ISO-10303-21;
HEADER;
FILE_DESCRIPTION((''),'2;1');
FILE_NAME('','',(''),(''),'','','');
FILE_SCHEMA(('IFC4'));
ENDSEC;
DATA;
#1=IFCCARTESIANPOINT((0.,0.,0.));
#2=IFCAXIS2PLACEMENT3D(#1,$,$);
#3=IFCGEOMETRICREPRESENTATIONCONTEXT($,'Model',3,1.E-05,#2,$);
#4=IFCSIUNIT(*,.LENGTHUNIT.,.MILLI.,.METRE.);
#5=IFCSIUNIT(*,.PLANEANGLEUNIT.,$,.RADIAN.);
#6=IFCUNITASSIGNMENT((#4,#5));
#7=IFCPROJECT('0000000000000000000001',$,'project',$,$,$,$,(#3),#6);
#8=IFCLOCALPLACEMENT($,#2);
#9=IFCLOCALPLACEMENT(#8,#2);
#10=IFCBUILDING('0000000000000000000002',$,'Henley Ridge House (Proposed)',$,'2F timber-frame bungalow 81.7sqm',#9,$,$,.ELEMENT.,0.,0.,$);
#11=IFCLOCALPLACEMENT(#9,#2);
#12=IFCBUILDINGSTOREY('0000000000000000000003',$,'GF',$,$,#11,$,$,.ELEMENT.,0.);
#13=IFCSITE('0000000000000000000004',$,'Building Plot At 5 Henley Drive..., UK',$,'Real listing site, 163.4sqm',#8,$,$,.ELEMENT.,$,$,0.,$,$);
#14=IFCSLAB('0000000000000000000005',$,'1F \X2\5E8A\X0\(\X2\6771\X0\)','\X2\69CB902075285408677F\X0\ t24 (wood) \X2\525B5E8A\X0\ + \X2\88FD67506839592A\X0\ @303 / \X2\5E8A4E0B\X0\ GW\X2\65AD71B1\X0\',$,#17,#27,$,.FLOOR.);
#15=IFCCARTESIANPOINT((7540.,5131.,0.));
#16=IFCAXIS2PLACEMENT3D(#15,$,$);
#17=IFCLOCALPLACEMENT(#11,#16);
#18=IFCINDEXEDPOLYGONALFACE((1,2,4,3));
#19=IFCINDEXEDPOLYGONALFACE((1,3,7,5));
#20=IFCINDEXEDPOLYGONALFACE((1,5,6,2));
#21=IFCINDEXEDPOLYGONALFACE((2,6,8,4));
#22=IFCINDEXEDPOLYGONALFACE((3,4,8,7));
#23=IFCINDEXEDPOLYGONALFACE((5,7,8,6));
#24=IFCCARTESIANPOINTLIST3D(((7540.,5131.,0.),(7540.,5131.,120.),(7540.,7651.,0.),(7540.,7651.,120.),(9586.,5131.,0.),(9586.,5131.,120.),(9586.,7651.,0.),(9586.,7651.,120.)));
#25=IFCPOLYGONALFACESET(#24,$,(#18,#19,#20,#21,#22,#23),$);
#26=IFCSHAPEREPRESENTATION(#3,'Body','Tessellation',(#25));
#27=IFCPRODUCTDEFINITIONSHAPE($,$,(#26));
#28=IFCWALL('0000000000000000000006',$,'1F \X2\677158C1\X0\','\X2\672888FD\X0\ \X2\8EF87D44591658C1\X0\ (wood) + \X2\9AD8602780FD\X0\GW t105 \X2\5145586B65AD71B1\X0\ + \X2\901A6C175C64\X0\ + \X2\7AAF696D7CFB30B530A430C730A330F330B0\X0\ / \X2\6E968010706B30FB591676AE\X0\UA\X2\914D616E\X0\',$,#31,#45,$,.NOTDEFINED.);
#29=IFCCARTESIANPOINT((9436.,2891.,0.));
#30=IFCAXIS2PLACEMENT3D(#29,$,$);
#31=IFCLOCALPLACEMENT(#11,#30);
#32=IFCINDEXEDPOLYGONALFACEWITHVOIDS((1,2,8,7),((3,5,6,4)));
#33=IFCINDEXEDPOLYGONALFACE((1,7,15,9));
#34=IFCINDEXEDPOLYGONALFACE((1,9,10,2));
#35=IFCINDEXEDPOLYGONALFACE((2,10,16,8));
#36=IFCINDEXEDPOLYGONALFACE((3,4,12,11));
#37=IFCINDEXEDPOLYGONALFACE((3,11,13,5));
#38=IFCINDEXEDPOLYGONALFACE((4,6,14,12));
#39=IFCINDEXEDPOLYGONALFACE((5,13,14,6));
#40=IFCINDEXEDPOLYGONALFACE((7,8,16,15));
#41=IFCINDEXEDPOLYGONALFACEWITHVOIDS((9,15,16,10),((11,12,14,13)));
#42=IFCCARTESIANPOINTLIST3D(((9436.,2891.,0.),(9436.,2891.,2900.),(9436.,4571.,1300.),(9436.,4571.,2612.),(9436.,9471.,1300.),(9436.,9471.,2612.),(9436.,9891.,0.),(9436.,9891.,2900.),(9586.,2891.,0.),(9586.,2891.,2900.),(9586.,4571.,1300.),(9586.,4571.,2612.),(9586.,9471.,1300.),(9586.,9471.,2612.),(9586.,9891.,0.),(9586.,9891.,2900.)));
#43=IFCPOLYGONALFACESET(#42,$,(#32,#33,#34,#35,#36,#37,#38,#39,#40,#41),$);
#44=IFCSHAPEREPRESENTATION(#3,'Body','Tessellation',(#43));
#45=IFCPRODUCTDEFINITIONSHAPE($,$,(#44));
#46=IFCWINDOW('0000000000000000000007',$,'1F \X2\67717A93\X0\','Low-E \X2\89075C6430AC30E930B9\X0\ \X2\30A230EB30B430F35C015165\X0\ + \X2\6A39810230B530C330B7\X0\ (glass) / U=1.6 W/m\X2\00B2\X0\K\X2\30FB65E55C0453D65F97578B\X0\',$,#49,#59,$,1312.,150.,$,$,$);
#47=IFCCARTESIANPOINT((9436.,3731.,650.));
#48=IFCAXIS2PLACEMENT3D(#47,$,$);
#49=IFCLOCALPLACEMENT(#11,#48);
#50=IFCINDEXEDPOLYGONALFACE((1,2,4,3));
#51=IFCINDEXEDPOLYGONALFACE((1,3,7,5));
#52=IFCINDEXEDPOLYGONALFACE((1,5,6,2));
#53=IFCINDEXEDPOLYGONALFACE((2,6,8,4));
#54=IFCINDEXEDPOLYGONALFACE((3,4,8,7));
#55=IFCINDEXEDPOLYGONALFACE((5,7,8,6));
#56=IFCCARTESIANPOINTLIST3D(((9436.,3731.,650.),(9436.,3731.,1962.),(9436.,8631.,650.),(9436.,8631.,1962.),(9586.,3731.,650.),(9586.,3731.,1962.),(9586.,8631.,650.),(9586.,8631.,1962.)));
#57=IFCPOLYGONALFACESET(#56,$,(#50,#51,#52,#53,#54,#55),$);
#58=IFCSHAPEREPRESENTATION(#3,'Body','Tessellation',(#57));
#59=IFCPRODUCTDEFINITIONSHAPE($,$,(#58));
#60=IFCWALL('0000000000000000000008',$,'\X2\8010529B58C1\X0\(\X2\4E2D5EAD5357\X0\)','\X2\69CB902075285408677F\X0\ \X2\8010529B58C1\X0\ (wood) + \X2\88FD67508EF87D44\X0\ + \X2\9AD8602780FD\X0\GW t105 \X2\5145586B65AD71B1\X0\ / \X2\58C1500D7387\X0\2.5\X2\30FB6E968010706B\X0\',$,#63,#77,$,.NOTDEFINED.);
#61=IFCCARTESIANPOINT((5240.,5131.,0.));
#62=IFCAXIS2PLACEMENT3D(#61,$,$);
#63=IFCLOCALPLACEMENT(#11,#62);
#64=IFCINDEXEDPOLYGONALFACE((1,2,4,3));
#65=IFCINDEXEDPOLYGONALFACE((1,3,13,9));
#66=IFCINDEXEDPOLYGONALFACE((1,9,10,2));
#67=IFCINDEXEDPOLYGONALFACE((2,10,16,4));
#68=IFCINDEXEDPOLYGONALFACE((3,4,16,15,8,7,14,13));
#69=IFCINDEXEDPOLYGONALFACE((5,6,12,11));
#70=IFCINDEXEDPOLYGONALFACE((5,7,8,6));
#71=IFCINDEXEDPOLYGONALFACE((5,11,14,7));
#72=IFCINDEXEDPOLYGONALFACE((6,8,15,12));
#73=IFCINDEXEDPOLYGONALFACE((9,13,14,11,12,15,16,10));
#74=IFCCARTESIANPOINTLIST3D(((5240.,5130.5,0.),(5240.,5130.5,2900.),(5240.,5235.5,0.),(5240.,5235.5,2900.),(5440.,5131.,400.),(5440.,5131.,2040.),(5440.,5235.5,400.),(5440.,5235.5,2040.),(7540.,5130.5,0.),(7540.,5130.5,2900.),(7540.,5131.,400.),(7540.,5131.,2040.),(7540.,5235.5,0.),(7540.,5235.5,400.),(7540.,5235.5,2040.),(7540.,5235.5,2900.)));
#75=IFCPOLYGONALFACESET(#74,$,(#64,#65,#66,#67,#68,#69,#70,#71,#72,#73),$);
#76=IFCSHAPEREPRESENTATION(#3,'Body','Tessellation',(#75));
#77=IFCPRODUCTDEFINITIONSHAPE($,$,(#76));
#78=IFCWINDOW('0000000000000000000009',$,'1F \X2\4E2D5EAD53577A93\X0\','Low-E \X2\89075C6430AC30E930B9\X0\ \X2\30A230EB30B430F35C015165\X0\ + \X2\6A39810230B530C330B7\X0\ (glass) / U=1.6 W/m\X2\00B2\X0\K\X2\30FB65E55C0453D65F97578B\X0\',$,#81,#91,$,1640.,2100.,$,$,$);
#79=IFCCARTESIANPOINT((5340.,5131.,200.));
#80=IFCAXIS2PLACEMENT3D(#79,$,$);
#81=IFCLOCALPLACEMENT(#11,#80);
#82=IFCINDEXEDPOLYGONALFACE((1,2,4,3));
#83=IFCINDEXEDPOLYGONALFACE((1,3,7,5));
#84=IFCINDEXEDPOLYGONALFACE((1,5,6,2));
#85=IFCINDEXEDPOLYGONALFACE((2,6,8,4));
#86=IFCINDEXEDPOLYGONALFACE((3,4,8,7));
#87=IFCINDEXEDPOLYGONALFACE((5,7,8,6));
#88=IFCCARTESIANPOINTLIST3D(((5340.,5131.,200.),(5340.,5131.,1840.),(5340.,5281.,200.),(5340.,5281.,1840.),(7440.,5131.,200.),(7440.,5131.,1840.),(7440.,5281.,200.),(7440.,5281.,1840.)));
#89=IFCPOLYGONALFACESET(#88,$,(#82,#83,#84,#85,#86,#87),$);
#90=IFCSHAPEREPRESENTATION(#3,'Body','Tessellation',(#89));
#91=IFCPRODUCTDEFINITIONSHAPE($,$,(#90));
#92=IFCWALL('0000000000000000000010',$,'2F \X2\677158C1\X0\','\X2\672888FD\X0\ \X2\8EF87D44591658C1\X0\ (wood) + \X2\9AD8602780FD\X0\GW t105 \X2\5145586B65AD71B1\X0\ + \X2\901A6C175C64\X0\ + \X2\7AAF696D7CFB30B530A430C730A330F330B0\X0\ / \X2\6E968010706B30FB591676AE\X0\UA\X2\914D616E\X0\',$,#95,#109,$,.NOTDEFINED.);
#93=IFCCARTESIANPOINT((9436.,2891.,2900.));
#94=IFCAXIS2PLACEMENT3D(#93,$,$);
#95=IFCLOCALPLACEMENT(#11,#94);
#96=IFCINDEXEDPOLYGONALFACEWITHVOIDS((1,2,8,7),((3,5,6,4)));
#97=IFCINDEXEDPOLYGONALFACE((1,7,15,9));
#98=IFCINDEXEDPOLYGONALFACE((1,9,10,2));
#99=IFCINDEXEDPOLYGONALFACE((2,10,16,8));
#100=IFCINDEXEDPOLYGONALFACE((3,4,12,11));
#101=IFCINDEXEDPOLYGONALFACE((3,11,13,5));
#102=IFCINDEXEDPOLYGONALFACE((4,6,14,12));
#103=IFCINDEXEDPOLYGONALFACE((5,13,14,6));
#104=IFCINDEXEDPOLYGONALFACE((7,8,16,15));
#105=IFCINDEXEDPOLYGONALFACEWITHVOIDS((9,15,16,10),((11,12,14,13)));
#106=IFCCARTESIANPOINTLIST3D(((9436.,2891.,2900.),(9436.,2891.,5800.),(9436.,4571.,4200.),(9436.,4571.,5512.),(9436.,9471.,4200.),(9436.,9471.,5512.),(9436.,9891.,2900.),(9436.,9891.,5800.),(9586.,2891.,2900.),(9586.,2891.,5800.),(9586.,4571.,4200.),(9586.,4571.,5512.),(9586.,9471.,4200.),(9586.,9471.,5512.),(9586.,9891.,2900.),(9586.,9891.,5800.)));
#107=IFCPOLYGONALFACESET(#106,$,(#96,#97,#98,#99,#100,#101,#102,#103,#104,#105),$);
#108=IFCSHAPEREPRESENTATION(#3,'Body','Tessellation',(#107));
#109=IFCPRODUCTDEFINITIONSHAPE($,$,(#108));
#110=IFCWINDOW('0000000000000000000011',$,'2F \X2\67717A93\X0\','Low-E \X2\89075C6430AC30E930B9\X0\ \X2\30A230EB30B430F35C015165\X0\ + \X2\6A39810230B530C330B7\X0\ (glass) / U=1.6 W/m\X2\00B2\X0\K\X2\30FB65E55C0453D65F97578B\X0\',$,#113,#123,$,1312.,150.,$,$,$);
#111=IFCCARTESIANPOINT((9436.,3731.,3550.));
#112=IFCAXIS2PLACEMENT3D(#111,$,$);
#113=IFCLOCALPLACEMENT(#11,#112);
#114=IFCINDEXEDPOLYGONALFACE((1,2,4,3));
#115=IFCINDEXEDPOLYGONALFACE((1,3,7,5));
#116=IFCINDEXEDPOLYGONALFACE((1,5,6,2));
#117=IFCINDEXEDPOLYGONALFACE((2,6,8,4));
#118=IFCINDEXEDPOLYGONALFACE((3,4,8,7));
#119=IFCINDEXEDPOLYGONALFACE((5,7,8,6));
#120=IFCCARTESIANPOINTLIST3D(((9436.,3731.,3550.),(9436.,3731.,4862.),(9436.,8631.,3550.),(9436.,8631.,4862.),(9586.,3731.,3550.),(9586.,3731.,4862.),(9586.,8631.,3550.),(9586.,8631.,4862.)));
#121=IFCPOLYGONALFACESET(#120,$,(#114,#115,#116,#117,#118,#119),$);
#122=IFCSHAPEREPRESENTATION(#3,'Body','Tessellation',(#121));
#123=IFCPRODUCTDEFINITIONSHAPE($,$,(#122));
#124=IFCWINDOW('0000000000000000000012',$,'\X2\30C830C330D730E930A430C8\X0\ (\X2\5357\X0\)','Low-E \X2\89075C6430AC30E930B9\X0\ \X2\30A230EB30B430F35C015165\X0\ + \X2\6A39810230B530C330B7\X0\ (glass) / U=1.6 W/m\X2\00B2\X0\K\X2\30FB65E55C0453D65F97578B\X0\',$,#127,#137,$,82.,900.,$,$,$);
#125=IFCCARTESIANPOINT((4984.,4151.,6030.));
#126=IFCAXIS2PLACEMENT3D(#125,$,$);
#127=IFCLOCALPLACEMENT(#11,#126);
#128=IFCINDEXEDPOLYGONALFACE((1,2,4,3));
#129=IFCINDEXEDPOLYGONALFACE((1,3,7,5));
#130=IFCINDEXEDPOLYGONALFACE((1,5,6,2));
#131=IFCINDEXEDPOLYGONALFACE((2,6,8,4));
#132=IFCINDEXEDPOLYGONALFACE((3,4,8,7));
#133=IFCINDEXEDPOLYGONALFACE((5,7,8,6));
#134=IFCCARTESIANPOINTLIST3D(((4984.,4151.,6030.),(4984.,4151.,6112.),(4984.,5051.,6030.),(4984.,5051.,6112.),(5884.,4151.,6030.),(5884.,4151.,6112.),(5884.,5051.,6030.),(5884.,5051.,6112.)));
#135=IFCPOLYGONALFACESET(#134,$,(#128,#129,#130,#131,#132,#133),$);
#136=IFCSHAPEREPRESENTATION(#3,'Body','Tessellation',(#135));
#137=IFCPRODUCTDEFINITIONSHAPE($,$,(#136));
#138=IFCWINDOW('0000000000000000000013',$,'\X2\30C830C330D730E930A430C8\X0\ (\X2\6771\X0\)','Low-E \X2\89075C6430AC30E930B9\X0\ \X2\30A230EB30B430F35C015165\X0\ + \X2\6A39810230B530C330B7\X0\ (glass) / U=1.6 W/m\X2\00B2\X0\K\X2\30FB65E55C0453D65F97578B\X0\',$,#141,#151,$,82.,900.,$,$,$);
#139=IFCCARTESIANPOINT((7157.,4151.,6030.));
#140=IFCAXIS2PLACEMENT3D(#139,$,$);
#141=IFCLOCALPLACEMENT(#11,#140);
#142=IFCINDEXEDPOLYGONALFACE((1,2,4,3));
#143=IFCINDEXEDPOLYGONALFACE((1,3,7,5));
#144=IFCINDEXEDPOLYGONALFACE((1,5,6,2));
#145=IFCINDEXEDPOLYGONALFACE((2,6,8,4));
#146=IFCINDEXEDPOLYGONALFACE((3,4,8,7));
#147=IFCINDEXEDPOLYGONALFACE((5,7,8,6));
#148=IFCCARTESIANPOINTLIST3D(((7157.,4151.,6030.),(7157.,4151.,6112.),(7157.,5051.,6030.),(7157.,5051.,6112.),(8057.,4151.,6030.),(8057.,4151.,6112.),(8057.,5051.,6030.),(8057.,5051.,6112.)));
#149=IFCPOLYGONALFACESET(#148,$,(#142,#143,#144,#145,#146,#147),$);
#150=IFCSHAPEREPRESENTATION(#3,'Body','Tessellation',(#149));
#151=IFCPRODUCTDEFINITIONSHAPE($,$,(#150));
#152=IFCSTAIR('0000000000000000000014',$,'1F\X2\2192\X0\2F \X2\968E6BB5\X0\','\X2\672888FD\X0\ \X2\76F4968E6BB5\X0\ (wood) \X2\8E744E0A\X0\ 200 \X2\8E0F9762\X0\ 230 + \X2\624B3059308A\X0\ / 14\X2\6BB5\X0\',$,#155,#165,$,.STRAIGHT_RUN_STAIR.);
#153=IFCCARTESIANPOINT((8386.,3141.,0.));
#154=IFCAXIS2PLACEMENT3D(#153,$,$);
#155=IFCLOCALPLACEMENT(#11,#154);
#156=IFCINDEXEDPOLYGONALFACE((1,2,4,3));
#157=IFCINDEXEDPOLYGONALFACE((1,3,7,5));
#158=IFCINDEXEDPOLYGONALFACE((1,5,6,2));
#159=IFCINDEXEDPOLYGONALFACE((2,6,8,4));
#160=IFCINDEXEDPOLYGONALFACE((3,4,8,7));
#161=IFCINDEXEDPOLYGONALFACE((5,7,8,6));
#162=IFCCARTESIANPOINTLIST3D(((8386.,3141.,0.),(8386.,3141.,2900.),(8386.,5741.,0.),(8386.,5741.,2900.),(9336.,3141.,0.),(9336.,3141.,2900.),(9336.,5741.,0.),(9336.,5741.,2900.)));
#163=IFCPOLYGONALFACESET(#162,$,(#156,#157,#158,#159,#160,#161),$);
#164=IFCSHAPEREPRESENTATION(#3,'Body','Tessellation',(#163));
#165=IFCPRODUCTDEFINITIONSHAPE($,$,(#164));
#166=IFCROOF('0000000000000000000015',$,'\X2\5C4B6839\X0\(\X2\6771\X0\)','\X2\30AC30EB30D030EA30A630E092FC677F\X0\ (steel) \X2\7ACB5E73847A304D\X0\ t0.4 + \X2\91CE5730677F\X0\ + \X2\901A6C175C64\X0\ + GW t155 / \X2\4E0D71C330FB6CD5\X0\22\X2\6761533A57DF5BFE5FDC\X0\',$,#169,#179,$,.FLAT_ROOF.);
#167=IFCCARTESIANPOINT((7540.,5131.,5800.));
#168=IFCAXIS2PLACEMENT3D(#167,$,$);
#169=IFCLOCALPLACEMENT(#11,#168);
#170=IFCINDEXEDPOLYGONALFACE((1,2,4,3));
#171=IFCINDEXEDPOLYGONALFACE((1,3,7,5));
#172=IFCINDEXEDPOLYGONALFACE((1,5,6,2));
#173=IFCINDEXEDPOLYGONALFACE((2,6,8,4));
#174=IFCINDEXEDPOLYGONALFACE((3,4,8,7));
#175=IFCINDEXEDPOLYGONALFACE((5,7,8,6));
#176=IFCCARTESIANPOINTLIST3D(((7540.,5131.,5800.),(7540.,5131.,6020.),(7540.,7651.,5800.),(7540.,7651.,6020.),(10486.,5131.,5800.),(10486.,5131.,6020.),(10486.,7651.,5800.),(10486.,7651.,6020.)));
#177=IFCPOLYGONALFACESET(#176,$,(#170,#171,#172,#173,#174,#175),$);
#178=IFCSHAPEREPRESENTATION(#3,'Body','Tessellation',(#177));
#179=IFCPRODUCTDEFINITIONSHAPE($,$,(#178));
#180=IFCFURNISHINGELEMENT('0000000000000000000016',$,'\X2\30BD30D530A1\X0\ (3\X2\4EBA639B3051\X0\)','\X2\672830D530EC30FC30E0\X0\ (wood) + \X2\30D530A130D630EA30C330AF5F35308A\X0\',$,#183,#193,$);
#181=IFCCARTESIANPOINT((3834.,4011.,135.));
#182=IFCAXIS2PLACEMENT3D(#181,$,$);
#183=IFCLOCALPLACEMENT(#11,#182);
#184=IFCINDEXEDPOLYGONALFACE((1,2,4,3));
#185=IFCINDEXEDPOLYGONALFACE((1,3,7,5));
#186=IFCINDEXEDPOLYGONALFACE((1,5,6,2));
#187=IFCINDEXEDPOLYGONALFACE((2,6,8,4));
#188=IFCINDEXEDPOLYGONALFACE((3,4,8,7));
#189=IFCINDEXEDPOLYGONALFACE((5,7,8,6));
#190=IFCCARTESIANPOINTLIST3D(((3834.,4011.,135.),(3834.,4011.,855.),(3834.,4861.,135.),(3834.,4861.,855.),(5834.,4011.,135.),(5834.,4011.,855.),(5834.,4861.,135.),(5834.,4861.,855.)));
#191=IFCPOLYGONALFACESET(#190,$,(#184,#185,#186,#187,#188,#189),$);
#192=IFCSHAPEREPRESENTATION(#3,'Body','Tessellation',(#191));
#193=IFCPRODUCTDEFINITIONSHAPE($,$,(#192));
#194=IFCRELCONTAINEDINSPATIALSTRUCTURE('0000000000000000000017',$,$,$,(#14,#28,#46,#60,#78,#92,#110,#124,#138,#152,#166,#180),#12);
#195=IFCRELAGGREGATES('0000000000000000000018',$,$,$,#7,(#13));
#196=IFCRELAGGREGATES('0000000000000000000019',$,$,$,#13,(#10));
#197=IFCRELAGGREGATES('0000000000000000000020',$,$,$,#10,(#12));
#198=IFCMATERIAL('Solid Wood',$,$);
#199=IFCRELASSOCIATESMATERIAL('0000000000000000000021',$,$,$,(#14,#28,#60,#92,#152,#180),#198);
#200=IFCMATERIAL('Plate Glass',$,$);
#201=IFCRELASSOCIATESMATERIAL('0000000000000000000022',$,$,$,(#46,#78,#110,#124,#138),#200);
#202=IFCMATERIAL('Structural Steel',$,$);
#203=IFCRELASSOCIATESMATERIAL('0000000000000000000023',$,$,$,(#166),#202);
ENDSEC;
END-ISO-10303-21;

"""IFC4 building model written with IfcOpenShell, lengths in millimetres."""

from ifc_helpers import new_model, si_unit, frame, frame_2d, origin, place, context, project, spatial, rectangle, extrude, material, element, fill, save


model = new_model("IFC4")

# Units and contexts
model_context = context("Model", 3, precision=1e-05, world=origin())
ifc_project = project(units=[si_unit("LENGTHUNIT", "METRE", prefix="MILLI"), si_unit("PLANEANGLEUNIT", "RADIAN")], contexts=[model_context])

# Site, building, storey
site_placement = place(None, origin())
site = spatial("IfcSite", under=ifc_project, at=site_placement, Name="Building Plot At 5 Henley Drive..., UK", ObjectType="Real listing site, 163.4sqm", CompositionType="ELEMENT", RefElevation=0.0)
building_placement = place(site_placement, origin())
building = spatial("IfcBuilding", under=site, at=building_placement, Name="Henley Ridge House (Proposed)", ObjectType="2F timber-frame bungalow 81.7sqm", CompositionType="ELEMENT", ElevationOfRefHeight=0.0, ElevationOfTerrain=0.0)
storey_placement = place(building_placement, origin())
storey = spatial("IfcBuildingStorey", under=building, at=storey_placement, Name="GF", CompositionType="ELEMENT", Elevation=0.0)

# Slab
ifc_material_1 = material(Name="Solid Wood")
slab_placement = place(storey_placement, frame((7540.0, 5131.0, 0.0)))
element("IfcSlab", 1, at=slab_placement, inside=storey, material=ifc_material_1, Name="1F 床(東)", Description="構造用合板 t24 (wood) 剛床 + 製材根太 @303 / 床下 GW断熱", PredefinedType="FLOOR", context=model_context, shape_type="SweptSolid", body=[
    extrude(rectangle(XDim=2046.0, YDim=2520.0, at=frame_2d((1023.0, 1260.0))), frame((7540.0, 5131.0, 0.0)), (0.0, 0.0, 1.0), 120.0),
])

# Walls, openings, windows
wall_1_placement = place(storey_placement, frame((9436.0, 2891.0, 0.0)))
wall_1 = element("IfcWall", 2, at=wall_1_placement, inside=storey, material=ifc_material_1, Name="1F 東壁", Description="木製 軸組外壁 (wood) + 高性能GW t105 充填断熱 + 通気層 + 窯業系サイディング / 準耐火・外皮UA配慮", PredefinedType="NOTDEFINED", context=model_context, shape_type="SweptSolid", body=[
    extrude(rectangle(XDim=150.0, YDim=7000.0, at=frame_2d((75.0, 3500.0))), frame((9436.0, 2891.0, 0.0)), (0.0, 0.0, 1.0), 2900.0),
])
opening_1_placement = place(storey_placement, frame((9436.0, 3731.0, 650.0)))
opening_1 = element("IfcOpeningElement", 3, at=opening_1_placement, cuts=wall_1, PredefinedType="NOTDEFINED", context=model_context, shape_type="SweptSolid", body=[
    extrude(rectangle(XDim=150.0, YDim=4900.0, at=frame_2d((75.0, 2450.0))), frame((9436.0, 3731.0, 650.0)), (0.0, 0.0, 1.0), 1312.0),
])
ifc_material_2 = material(Name="Plate Glass")
window_1_placement = place(storey_placement, frame((9436.0, 3731.0, 650.0)))
window_1 = element("IfcWindow", 4, at=window_1_placement, inside=storey, material=ifc_material_2, Name="1F 東窓", Description="Low-E 複層ガラス アルゴン封入 + 樹脂サッシ (glass) / U=1.6 W/m²K・日射取得型", OverallHeight=1312.0, OverallWidth=150.0, context=model_context, shape_type="SweptSolid", body=[
    extrude(rectangle(XDim=150.0, YDim=4900.0, at=frame_2d((75.0, 2450.0))), frame((9436.0, 3731.0, 650.0)), (0.0, 0.0, 1.0), 1312.0),
])
fill(opening_1, window_1)
wall_2_placement = place(storey_placement, frame((5240.0, 5131.0, 0.0)))
wall_2 = element("IfcWall", 5, at=wall_2_placement, inside=storey, material=ifc_material_1, Name="耐力壁(中庭南)", Description="構造用合板 耐力壁 (wood) + 製材軸組 + 高性能GW t105 充填断熱 / 壁倍率2.5・準耐火", PredefinedType="NOTDEFINED", context=model_context, shape_type="SweptSolid", body=[
    extrude(rectangle(XDim=2300.0, YDim=105.0, at=frame_2d((1150.0, 52.0))), frame((5240.0, 5131.0, 0.0)), (0.0, 0.0, 1.0), 2900.0),
])
opening_2_placement = place(storey_placement, frame((5340.0, 5131.0, 200.0)))
opening_2 = element("IfcOpeningElement", 6, at=opening_2_placement, cuts=wall_2, PredefinedType="NOTDEFINED", context=model_context, shape_type="SweptSolid", body=[
    extrude(rectangle(XDim=2100.0, YDim=150.0, at=frame_2d((1050.0, 75.0))), frame((5340.0, 5131.0, 200.0)), (0.0, 0.0, 1.0), 1640.0),
])
window_2_placement = place(storey_placement, frame((5340.0, 5131.0, 200.0)))
window_2 = element("IfcWindow", 7, at=window_2_placement, inside=storey, material=ifc_material_2, Name="1F 中庭南窓", Description="Low-E 複層ガラス アルゴン封入 + 樹脂サッシ (glass) / U=1.6 W/m²K・日射取得型", OverallHeight=1640.0, OverallWidth=2100.0, context=model_context, shape_type="SweptSolid", body=[
    extrude(rectangle(XDim=2100.0, YDim=150.0, at=frame_2d((1050.0, 75.0))), frame((5340.0, 5131.0, 200.0)), (0.0, 0.0, 1.0), 1640.0),
])
fill(opening_2, window_2)

# Wall, opening, window
wall_3_placement = place(storey_placement, frame((9436.0, 2891.0, 2900.0)))
wall_3 = element("IfcWall", 8, at=wall_3_placement, inside=storey, material=ifc_material_1, Name="2F 東壁", Description="木製 軸組外壁 (wood) + 高性能GW t105 充填断熱 + 通気層 + 窯業系サイディング / 準耐火・外皮UA配慮", PredefinedType="NOTDEFINED", context=model_context, shape_type="SweptSolid", body=[
    extrude(rectangle(XDim=150.0, YDim=7000.0, at=frame_2d((75.0, 3500.0))), frame((9436.0, 2891.0, 2900.0)), (0.0, 0.0, 1.0), 2900.0),
])
opening_3_placement = place(storey_placement, frame((9436.0, 3731.0, 3550.0)))
opening_3 = element("IfcOpeningElement", 9, at=opening_3_placement, cuts=wall_3, PredefinedType="NOTDEFINED", context=model_context, shape_type="SweptSolid", body=[
    extrude(rectangle(XDim=150.0, YDim=4900.0, at=frame_2d((75.0, 2450.0))), frame((9436.0, 3731.0, 3550.0)), (0.0, 0.0, 1.0), 1312.0),
])
window_3_placement = place(storey_placement, frame((9436.0, 3731.0, 3550.0)))
window_3 = element("IfcWindow", 10, at=window_3_placement, inside=storey, material=ifc_material_2, Name="2F 東窓", Description="Low-E 複層ガラス アルゴン封入 + 樹脂サッシ (glass) / U=1.6 W/m²K・日射取得型", OverallHeight=1312.0, OverallWidth=150.0, context=model_context, shape_type="SweptSolid", body=[
    extrude(rectangle(XDim=150.0, YDim=4900.0, at=frame_2d((75.0, 2450.0))), frame((9436.0, 3731.0, 3550.0)), (0.0, 0.0, 1.0), 1312.0),
])
fill(opening_3, window_3)

# Windows
window_4_placement = place(storey_placement, frame((4984.0, 4151.0, 6030.0)))
element("IfcWindow", 11, at=window_4_placement, inside=storey, material=ifc_material_2, Name="トップライト (南)", Description="Low-E 複層ガラス アルゴン封入 + 樹脂サッシ (glass) / U=1.6 W/m²K・日射取得型", OverallHeight=82.0, OverallWidth=900.0, context=model_context, shape_type="SweptSolid", body=[
    extrude(rectangle(XDim=900.0, YDim=900.0, at=frame_2d((450.0, 450.0))), frame((4984.0, 4151.0, 6030.0)), (0.0, 0.0, 1.0), 82.0),
])
window_5_placement = place(storey_placement, frame((7157.0, 4151.0, 6030.0)))
element("IfcWindow", 12, at=window_5_placement, inside=storey, material=ifc_material_2, Name="トップライト (東)", Description="Low-E 複層ガラス アルゴン封入 + 樹脂サッシ (glass) / U=1.6 W/m²K・日射取得型", OverallHeight=82.0, OverallWidth=900.0, context=model_context, shape_type="SweptSolid", body=[
    extrude(rectangle(XDim=900.0, YDim=900.0, at=frame_2d((450.0, 450.0))), frame((7157.0, 4151.0, 6030.0)), (0.0, 0.0, 1.0), 82.0),
])

# Stair
stair_placement = place(storey_placement, frame((8386.0, 3141.0, 0.0)))
element("IfcStair", 13, at=stair_placement, inside=storey, material=ifc_material_1, Name="1F→2F 階段", Description="木製 直階段 (wood) 蹴上 200 踏面 230 + 手すり / 14段", PredefinedType="STRAIGHT_RUN_STAIR", context=model_context, shape_type="SweptSolid", body=[
    extrude(rectangle(XDim=950.0, YDim=2600.0, at=frame_2d((475.0, 1300.0))), frame((8386.0, 3141.0, 0.0)), (0.0, 0.0, 1.0), 2900.0),
])

# Roof
ifc_material_3 = material(Name="Structural Steel")
roof_placement = place(storey_placement, frame((7540.0, 5131.0, 5800.0)))
element("IfcRoof", 14, at=roof_placement, inside=storey, material=ifc_material_3, Name="屋根(東)", Description="ガルバリウム鋼板 (steel) 立平葺き t0.4 + 野地板 + 通気層 + GW t155 / 不燃・法22条区域対応", PredefinedType="FLAT_ROOF", context=model_context, shape_type="SweptSolid", body=[
    extrude(rectangle(XDim=2946.0, YDim=2520.0, at=frame_2d((1473.0, 1260.0))), frame((7540.0, 5131.0, 5800.0)), (0.0, 0.0, 1.0), 220.0),
])

# Furnishing element
furnishing_1_placement = place(storey_placement, frame((3834.0, 4011.0, 135.0)))
element("IfcFurnishingElement", 15, at=furnishing_1_placement, inside=storey, material=ifc_material_1, Name="ソファ (3人掛け)", Description="木フレーム (wood) + ファブリック張り", context=model_context, shape_type="SweptSolid", body=[
    extrude(rectangle(XDim=2000.0, YDim=850.0, at=frame_2d((1000.0, 425.0))), frame((3834.0, 4011.0, 135.0)), (0.0, 0.0, 1.0), 720.0),
])

save(model, "model.ifc")
